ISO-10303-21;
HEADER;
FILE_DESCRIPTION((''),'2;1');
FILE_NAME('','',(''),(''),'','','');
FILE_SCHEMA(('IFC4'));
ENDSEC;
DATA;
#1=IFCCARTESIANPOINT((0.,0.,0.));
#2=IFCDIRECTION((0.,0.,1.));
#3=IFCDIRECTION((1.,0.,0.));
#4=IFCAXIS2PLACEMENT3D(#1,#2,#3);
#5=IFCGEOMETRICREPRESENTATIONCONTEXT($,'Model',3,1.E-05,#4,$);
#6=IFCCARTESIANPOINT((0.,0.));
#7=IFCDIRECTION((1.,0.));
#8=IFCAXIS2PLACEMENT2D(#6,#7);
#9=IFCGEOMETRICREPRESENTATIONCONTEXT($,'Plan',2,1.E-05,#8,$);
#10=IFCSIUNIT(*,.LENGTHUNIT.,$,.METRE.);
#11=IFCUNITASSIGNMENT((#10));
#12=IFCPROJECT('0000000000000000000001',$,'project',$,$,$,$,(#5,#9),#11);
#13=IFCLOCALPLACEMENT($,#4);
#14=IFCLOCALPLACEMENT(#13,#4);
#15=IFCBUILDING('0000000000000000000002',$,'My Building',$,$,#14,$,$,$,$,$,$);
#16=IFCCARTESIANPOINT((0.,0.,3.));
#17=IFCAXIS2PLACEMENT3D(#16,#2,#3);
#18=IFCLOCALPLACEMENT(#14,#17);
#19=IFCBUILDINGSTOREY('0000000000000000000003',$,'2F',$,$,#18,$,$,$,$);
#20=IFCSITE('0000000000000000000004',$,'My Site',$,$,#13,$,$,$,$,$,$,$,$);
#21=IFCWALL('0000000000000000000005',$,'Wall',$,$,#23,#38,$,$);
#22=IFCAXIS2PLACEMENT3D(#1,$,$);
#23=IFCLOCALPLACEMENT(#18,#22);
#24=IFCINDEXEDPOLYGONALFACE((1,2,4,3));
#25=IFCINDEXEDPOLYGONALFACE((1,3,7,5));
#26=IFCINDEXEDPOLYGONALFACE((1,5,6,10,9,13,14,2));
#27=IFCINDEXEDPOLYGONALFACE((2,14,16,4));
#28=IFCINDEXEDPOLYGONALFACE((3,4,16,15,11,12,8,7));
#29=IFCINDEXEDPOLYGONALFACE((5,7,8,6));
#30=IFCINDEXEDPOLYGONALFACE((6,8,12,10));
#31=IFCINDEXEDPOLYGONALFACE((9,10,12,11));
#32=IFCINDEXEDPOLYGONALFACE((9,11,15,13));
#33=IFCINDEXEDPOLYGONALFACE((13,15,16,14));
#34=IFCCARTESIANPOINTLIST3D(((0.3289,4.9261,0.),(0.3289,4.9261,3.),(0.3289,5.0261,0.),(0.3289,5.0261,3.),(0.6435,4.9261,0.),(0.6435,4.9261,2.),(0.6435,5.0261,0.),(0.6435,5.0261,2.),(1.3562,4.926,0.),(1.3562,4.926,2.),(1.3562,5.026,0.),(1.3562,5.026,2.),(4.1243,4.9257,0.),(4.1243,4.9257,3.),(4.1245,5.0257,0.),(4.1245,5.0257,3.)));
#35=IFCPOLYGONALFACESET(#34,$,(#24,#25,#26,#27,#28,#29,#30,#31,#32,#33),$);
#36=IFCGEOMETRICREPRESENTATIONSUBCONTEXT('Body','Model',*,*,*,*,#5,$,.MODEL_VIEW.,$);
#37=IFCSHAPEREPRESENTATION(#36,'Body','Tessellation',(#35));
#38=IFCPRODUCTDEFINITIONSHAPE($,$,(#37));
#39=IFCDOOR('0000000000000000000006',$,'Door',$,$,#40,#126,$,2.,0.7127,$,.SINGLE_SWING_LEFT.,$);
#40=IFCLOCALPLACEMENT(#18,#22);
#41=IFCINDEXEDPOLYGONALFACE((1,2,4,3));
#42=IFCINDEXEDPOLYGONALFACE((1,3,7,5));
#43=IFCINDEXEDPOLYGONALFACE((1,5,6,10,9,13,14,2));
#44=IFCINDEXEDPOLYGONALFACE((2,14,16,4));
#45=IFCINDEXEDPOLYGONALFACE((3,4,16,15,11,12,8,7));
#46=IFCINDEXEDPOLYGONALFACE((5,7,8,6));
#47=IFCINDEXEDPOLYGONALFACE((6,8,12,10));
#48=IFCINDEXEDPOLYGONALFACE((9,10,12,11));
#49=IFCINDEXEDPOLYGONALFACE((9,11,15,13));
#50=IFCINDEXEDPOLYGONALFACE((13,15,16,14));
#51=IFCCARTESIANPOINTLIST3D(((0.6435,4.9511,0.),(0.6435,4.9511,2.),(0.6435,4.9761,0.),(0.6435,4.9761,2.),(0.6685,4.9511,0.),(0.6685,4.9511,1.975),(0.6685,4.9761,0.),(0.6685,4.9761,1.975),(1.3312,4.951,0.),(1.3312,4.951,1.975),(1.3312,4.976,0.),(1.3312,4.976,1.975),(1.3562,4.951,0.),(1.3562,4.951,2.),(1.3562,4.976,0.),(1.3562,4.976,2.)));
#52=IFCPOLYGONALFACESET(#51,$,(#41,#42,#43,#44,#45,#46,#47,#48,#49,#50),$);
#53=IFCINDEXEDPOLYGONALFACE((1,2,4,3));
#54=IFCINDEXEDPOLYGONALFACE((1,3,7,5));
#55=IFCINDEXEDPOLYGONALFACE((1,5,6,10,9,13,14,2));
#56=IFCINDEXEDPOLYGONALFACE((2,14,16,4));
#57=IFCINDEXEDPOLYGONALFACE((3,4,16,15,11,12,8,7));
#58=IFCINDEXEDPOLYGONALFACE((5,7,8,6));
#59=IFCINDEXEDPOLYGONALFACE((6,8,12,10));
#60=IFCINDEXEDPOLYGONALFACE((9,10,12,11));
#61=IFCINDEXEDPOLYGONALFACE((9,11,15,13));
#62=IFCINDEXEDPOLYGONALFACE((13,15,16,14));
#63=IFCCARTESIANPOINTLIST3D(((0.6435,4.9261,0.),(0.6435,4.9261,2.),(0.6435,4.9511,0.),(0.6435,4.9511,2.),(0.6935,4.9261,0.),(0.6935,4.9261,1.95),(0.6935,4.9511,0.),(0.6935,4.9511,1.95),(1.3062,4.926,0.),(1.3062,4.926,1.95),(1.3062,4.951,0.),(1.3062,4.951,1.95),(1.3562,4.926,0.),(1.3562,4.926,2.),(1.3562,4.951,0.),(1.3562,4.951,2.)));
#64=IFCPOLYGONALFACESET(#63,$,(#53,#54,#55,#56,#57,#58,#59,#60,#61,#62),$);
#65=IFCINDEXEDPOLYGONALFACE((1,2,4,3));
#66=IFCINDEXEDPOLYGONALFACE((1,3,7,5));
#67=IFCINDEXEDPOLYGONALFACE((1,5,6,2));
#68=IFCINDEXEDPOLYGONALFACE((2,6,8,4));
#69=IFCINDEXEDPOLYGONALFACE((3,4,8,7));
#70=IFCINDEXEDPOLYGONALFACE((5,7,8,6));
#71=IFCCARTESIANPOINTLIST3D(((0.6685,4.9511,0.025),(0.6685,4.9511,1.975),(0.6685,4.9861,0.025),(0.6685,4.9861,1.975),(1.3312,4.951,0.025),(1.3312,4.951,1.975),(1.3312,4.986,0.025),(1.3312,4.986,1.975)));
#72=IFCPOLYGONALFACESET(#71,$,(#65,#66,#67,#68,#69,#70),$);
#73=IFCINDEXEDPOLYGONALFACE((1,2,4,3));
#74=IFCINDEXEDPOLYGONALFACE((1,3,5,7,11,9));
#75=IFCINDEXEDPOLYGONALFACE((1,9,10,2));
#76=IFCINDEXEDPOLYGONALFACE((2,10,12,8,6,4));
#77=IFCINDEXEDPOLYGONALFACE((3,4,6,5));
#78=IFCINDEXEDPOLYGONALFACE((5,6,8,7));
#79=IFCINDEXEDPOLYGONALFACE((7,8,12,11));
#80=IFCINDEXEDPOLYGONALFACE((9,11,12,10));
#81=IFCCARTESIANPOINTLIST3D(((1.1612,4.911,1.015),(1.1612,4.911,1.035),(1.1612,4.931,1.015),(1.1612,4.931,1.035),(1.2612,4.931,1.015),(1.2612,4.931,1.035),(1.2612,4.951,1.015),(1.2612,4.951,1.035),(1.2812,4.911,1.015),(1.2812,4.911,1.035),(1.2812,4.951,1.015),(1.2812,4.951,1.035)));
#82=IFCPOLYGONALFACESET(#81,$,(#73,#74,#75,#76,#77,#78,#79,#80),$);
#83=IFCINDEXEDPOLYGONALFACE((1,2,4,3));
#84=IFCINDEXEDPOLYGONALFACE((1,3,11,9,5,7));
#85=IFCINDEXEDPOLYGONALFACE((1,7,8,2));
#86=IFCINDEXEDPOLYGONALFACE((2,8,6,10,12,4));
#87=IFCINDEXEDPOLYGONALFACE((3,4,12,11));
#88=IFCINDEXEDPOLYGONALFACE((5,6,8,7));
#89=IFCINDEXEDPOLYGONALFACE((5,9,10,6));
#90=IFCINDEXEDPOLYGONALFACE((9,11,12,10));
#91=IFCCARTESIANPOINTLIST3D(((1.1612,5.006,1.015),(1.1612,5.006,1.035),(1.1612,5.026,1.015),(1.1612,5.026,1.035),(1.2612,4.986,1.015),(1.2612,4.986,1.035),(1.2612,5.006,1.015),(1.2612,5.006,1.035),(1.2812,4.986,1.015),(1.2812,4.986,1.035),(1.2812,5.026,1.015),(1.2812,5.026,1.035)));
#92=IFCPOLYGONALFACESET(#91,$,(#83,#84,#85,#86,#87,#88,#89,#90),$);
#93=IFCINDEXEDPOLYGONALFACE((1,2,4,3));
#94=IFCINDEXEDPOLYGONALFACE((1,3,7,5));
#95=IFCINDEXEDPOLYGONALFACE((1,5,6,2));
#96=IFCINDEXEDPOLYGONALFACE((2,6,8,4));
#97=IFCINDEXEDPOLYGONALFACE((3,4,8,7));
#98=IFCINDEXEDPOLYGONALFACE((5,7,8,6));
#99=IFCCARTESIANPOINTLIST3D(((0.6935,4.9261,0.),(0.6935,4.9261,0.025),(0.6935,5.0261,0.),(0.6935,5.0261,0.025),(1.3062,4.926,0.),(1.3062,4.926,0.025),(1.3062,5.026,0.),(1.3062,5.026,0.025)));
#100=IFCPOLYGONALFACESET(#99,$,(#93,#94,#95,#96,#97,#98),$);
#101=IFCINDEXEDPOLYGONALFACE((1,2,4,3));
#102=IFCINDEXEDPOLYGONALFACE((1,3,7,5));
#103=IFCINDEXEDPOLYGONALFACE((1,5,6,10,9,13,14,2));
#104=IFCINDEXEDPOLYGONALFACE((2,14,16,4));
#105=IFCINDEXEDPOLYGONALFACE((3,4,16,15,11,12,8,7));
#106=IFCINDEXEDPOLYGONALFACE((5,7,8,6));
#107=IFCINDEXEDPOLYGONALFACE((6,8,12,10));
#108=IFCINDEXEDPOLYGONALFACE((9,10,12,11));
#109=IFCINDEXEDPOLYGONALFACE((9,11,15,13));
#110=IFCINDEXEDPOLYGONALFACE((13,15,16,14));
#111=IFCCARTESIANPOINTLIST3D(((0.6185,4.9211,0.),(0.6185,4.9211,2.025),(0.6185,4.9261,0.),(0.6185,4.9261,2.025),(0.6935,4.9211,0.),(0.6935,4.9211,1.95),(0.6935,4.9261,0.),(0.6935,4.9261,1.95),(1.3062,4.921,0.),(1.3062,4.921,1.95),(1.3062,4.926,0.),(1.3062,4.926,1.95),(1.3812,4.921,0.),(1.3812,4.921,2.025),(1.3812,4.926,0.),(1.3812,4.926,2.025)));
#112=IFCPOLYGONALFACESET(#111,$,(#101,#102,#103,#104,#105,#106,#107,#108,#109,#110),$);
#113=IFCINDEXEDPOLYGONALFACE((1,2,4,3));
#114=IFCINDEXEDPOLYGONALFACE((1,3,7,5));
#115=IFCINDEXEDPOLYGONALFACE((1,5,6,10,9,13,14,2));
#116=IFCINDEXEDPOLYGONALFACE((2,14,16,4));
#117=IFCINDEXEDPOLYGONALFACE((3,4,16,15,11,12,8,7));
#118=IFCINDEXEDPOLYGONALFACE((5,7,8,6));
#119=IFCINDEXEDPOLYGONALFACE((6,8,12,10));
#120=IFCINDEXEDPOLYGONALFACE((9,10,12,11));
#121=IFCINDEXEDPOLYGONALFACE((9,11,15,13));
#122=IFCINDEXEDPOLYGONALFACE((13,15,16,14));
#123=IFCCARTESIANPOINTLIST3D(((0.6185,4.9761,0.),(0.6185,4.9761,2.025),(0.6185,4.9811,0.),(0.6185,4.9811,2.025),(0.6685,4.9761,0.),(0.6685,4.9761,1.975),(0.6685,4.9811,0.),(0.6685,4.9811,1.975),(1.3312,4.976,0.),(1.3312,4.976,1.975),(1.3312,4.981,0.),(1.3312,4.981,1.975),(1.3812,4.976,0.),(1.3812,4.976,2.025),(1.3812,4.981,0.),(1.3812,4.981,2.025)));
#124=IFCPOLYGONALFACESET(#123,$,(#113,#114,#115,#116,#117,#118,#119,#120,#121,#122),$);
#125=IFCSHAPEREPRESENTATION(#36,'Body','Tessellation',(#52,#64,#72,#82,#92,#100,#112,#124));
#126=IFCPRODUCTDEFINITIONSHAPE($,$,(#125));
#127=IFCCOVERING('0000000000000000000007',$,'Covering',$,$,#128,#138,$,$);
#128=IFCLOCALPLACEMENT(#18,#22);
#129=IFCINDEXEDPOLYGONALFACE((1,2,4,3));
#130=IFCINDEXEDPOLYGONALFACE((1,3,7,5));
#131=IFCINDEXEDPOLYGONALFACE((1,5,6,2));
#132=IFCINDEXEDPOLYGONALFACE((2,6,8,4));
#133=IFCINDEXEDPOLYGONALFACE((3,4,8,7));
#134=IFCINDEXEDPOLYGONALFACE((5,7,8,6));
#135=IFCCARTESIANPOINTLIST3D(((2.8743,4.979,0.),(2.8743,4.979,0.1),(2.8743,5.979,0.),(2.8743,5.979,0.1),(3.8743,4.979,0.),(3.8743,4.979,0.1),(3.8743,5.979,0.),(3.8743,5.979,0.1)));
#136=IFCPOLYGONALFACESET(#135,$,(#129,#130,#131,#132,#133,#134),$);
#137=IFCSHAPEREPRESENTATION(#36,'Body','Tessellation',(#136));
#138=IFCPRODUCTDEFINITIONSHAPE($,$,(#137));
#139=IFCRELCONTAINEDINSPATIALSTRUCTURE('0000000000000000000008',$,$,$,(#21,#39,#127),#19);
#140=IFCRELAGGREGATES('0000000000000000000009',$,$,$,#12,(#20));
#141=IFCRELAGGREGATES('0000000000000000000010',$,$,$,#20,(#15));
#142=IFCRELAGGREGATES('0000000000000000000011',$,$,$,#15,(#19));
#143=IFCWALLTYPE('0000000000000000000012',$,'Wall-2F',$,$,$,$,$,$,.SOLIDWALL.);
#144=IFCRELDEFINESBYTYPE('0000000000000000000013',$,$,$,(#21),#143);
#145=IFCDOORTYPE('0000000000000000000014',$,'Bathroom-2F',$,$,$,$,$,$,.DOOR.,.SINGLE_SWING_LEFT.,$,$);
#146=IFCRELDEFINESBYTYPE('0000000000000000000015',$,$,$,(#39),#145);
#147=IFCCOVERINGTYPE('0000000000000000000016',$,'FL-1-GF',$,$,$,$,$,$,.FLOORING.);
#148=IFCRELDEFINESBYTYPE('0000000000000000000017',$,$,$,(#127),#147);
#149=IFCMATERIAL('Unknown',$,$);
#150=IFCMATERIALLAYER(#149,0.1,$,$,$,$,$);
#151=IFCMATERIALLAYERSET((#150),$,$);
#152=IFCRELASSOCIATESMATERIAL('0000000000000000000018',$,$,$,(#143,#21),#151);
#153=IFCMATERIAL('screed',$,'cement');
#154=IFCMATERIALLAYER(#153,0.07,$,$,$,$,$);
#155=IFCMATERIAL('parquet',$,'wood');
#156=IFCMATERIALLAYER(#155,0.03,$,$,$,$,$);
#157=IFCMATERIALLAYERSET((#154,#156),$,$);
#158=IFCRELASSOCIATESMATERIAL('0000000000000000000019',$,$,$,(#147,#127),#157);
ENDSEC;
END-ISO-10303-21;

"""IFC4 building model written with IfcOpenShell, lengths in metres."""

from ifc_helpers import new_model, entity, si_unit, frame, origin_with_axes, origin_2d_with_axis, place, context, subcontext, project, spatial, line, indexed_curve, outline, extrude, shape, source, transform, mapped, material, layer, layer_set, layer_usage, type_object, type_shapes, element, fill, save


model = new_model("IFC4")

# Units and contexts
model_context = context("Model", 3, precision=1e-05, world=origin_with_axes())
plan_context = context("Plan", 2, precision=1e-05, world=origin_2d_with_axis())
body_context_1 = subcontext(model_context, "Body", "Model", "MODEL_VIEW")
body_context_2 = subcontext(plan_context, "Body", "Plan", "PLAN_VIEW")
ifc_project = project(units=[si_unit("LENGTHUNIT", "METRE")], contexts=[model_context, plan_context])

# Site, building, storey
site_placement = place(None, origin_with_axes())
site = spatial("IfcSite", under=ifc_project, at=site_placement, Name="My Site")
building_placement = place(site_placement, origin_with_axes())
building = spatial("IfcBuilding", under=site, at=building_placement, Name="My Building")
storey_placement = place(building_placement, frame((0.0, 0.0, 3.0), z_axis=(0.0, 0.0, 1.0), x_axis=(1.0, 0.0, 0.0)))
storey = spatial("IfcBuildingStorey", under=building, at=storey_placement, Name="2F")

# Shared definitions
ifc_material_1 = material(Name="Unknown")

# Shared definitions
ifc_layer_1 = layer(ifc_material_1, 0.1)
ifc_layer_set_1 = layer_set([ifc_layer_1])
wall_type = type_object("IfcWallType", Name="Wall-2F", PredefinedType="SOLIDWALL", material=ifc_layer_set_1)

# Wall, opening, door
ifc_layer_usage_1 = layer_usage(ifc_layer_set_1, "AXIS2", "POSITIVE", 0.0)
wall_1_placement = place(storey_placement, frame((0.3289, 4.9261, 0.0), z_axis=(0.0, 0.0, 1.0), x_axis=(1.0, -0.000101, 0.0)))
wall_1 = element("IfcWall", 1, at=wall_1_placement, inside=storey, type_object=wall_type, material=ifc_layer_usage_1, Name="Wall", context=body_context_1, shape_type="SweptSolid", body=[
    extrude(outline(indexed_curve([(0.0, 0.0), (0.0, 0.1), (3.7955, 0.1), (3.7954, 0.0)], segments=[line(1, 2, 3, 4, 1)])), origin_with_axes(), (0.0, 0.0, 1.0), 3.0),
])
shared_shape_1 = source(origin_with_axes(), body_context_1, "Body", "SweptSolid", [
    extrude(outline(indexed_curve([(0.0, 0.0), (0.7127, 0.0), (0.7127, 2.0), (0.0, 2.0)], segments=[line(1, 2, 3, 4, 1)])), frame((0.0, -0.6, 0.0), z_axis=(0.0, -1.0, 0.0), x_axis=(1.0, 0.0, 0.0)), (0.0, 0.0, -1.0), 1.2),
])
opening_1_placement = place(wall_1_placement, frame((0.3146, 0.0, 0.0), z_axis=(0.0, 0.0, 1.0), x_axis=(1.0, 0.0, 0.0)))
opening_1 = element("IfcOpeningElement", 2, at=opening_1_placement, cuts=wall_1, PredefinedType="OPENING", context=body_context_1, shape_type="MappedRepresentation", body=[
    mapped(shared_shape_1, transform((0.0, 0.0, 0.0), x_axis=(1.0, 0.0, 0.0), y_axis=(0.0, 1.0, 0.0), z_axis=(0.0, 0.0, 1.0), scale=1.0)),
])
door_type = type_object("IfcDoorType", Name="Bathroom-2F", OperationType="SINGLE_SWING_LEFT", PredefinedType="DOOR")
shared_shape_2 = source(origin_with_axes(), body_context_1, "Body", "SweptSolid", [
    extrude(outline(indexed_curve([(0.0, 0.0), (0.0, 2.0), (0.7127, 2.0), (0.7127, 0.0), (0.6877, 0.0), (0.6877, 1.975), (0.025, 1.975), (0.025, 0.0)], segments=[line(1, 2, 3, 4, 5, 6, 7, 8, 1)])), frame((0.0, 0.025, 0.0), z_axis=(0.0, -1.0, 0.0), x_axis=(1.0, 0.0, 0.0)), (0.0, 0.0, -1.0), 0.025),
    extrude(outline(indexed_curve([(0.0, 0.0), (0.0, 2.0), (0.7127, 2.0), (0.7127, 0.0), (0.6627, 0.0), (0.6627, 1.95), (0.05, 1.95), (0.05, 0.0)], segments=[line(1, 2, 3, 4, 5, 6, 7, 8, 1)])), frame((0.0, 0.0, 0.0), z_axis=(0.0, -1.0, 0.0), x_axis=(1.0, 0.0, 0.0)), (0.0, 0.0, -1.0), 0.025),
    extrude(outline(indexed_curve([(0.0, 0.0), (0.6627, 0.0), (0.6627, 0.035), (0.0, 0.035)], segments=[line(1, 2, 3, 4, 1)])), frame((0.025, 0.025, 0.025), z_axis=(0.0, 0.0, 1.0), x_axis=(1.0, 0.0, 0.0)), (0.0, 0.0, 1.0), 1.95),
    extrude(outline(indexed_curve([(0.0, 0.0), (0.0, -0.04), (-0.12, -0.04), (-0.12, -0.02), (-0.02, -0.02), (-0.02, 0.0)], segments=[line(1, 2, 3, 4, 5, 6, 1)])), frame((0.6377, 0.025, 1.015), z_axis=(0.0, 0.0, 1.0), x_axis=(1.0, 0.0, 0.0)), (0.0, 0.0, 1.0), 0.02),
    extrude(outline(indexed_curve([(0.0, 0.0), (0.0, 0.04), (-0.12, 0.04), (-0.12, 0.02), (-0.02, 0.02), (-0.02, 0.0)], segments=[line(1, 2, 3, 4, 5, 6, 1)])), frame((0.6377, 0.06, 1.015), z_axis=(0.0, 0.0, 1.0), x_axis=(1.0, 0.0, 0.0)), (0.0, 0.0, 1.0), 0.02),
    extrude(outline(indexed_curve([(0.0, 0.0), (0.6127, 0.0), (0.6127, 0.1), (0.0, 0.1)], segments=[line(1, 2, 3, 4, 1)])), frame((0.05, 0.0, 0.0), z_axis=(0.0, 0.0, 1.0), x_axis=(1.0, 0.0, 0.0)), (0.0, 0.0, 1.0), 0.025),
    extrude(outline(indexed_curve([(0.0, 0.0), (0.0, 2.025), (0.7627, 2.025), (0.7627, 0.0), (0.6877, 0.0), (0.6877, 1.95), (0.075, 1.95), (0.075, 0.0)], segments=[line(1, 2, 3, 4, 5, 6, 7, 8, 1)])), frame((-0.025, -0.005, 0.0), z_axis=(0.0, -1.0, 0.0), x_axis=(1.0, 0.0, 0.0)), (0.0, 0.0, -1.0), 0.005),
    extrude(outline(indexed_curve([(0.0, 0.0), (0.0, 2.025), (0.7627, 2.025), (0.7627, 0.0), (0.7127, 0.0), (0.7127, 1.975), (0.05, 1.975), (0.05, 0.0)], segments=[line(1, 2, 3, 4, 5, 6, 7, 8, 1)])), frame((-0.025, 0.05, 0.0), z_axis=(0.0, -1.0, 0.0), x_axis=(1.0, 0.0, 0.0)), (0.0, 0.0, -1.0), 0.005),
])
shared_shape_3 = source(origin_with_axes(), body_context_2, "Body", "Curve2D", [
    entity("IfcIndexedPolyCurve", entity("IfcCartesianPointList2D", [[0.0, 0.0], [0.0, 0.05], [0.025, 0.05], [0.025, 0.025], [0.05, 0.025], [0.05, 0.0]]), [entity("IfcLineIndex", [1, 2, 3, 4, 5, 6, 1])]),
    entity("IfcIndexedPolyCurve", entity("IfcCartesianPointList2D", [[0.7127, 0.0], [0.7127, 0.05], [0.6877, 0.05], [0.6877, 0.025], [0.6627, 0.025], [0.6627, 0.0]]), [entity("IfcLineIndex", [1, 2, 3, 4, 5, 6, 1])]),
    entity("IfcTrimmedCurve", entity("IfcEllipse", entity("IfcAxis2Placement2D", entity("IfcCartesianPoint", [0.06, 0.05]), entity("IfcDirection", [1.0, 0.0])), 0.6277, 0.6627), [entity("IfcCartesianPoint", [0.6877, 0.05])], [entity("IfcCartesianPoint", [0.06, 0.7127])], True, "CARTESIAN"),
    entity("IfcIndexedPolyCurve", entity("IfcCartesianPointList2D", [[0.025, 0.05], [0.06, 0.05], [0.06, 0.7127], [0.025, 0.7127]]), [entity("IfcLineIndex", [1, 2, 3, 4, 1])]),
])
type_shapes(door_type, [shared_shape_2, shared_shape_3])
door_placement = place(opening_1_placement, frame((0.0, 0.0, 0.0), z_axis=(0.0, 0.0, 1.0), x_axis=(1.0, 0.0, 0.0)))
door = element("IfcDoor", 3, at=door_placement, inside=storey, type_object=door_type, Name="Door", OperationType="SINGLE_SWING_LEFT", OverallHeight=2.0, OverallWidth=0.7127, shapes=[
    shape(body_context_1, "Body", "MappedRepresentation", [mapped(shared_shape_2, transform((0.0, 0.0, 0.0), x_axis=(1.0, 0.0, 0.0), y_axis=(0.0, 1.0, 0.0), z_axis=(0.0, 0.0, 1.0), scale=1.0))]),
    shape(body_context_2, "Body", "MappedRepresentation", [mapped(shared_shape_3, transform((0.0, 0.0, 0.0), x_axis=(1.0, 0.0, 0.0), y_axis=(0.0, 1.0, 0.0), z_axis=(0.0, 0.0, 1.0), scale=1.0))]),
])
fill(opening_1, door)

# Covering
ifc_material_2 = material(Name="screed", Category="cement")
ifc_layer_2 = layer(ifc_material_2, 0.07)
ifc_material_3 = material(Name="parquet", Category="wood")
ifc_layer_3 = layer(ifc_material_3, 0.03)
ifc_layer_set_2 = layer_set([ifc_layer_2, ifc_layer_3])
ifc_layer_usage_2 = layer_usage(ifc_layer_set_2, "AXIS3", "POSITIVE", 0.0)
covering_type = type_object("IfcCoveringType", Name="FL-1-GF", PredefinedType="FLOORING", material=ifc_layer_set_2)
covering_1_placement = place(storey_placement, frame((2.8743, 4.979, 0.0), z_axis=(0.0, 0.0, 1.0), x_axis=(1.0, 0.0, 0.0)))
element("IfcCovering", 4, at=covering_1_placement, inside=storey, type_object=covering_type, material=ifc_layer_usage_2, Name="Covering", context=body_context_1, shape_type="SweptSolid", body=[
    extrude(outline(indexed_curve([(0.0, 0.0), (1.0, 0.0), (1.0, 1.0), (0.0, 1.0), (0.0, 0.0)])), origin_with_axes(), (0.0, 0.0, 1.0), 0.1),
])

save(model, "model.ifc")
